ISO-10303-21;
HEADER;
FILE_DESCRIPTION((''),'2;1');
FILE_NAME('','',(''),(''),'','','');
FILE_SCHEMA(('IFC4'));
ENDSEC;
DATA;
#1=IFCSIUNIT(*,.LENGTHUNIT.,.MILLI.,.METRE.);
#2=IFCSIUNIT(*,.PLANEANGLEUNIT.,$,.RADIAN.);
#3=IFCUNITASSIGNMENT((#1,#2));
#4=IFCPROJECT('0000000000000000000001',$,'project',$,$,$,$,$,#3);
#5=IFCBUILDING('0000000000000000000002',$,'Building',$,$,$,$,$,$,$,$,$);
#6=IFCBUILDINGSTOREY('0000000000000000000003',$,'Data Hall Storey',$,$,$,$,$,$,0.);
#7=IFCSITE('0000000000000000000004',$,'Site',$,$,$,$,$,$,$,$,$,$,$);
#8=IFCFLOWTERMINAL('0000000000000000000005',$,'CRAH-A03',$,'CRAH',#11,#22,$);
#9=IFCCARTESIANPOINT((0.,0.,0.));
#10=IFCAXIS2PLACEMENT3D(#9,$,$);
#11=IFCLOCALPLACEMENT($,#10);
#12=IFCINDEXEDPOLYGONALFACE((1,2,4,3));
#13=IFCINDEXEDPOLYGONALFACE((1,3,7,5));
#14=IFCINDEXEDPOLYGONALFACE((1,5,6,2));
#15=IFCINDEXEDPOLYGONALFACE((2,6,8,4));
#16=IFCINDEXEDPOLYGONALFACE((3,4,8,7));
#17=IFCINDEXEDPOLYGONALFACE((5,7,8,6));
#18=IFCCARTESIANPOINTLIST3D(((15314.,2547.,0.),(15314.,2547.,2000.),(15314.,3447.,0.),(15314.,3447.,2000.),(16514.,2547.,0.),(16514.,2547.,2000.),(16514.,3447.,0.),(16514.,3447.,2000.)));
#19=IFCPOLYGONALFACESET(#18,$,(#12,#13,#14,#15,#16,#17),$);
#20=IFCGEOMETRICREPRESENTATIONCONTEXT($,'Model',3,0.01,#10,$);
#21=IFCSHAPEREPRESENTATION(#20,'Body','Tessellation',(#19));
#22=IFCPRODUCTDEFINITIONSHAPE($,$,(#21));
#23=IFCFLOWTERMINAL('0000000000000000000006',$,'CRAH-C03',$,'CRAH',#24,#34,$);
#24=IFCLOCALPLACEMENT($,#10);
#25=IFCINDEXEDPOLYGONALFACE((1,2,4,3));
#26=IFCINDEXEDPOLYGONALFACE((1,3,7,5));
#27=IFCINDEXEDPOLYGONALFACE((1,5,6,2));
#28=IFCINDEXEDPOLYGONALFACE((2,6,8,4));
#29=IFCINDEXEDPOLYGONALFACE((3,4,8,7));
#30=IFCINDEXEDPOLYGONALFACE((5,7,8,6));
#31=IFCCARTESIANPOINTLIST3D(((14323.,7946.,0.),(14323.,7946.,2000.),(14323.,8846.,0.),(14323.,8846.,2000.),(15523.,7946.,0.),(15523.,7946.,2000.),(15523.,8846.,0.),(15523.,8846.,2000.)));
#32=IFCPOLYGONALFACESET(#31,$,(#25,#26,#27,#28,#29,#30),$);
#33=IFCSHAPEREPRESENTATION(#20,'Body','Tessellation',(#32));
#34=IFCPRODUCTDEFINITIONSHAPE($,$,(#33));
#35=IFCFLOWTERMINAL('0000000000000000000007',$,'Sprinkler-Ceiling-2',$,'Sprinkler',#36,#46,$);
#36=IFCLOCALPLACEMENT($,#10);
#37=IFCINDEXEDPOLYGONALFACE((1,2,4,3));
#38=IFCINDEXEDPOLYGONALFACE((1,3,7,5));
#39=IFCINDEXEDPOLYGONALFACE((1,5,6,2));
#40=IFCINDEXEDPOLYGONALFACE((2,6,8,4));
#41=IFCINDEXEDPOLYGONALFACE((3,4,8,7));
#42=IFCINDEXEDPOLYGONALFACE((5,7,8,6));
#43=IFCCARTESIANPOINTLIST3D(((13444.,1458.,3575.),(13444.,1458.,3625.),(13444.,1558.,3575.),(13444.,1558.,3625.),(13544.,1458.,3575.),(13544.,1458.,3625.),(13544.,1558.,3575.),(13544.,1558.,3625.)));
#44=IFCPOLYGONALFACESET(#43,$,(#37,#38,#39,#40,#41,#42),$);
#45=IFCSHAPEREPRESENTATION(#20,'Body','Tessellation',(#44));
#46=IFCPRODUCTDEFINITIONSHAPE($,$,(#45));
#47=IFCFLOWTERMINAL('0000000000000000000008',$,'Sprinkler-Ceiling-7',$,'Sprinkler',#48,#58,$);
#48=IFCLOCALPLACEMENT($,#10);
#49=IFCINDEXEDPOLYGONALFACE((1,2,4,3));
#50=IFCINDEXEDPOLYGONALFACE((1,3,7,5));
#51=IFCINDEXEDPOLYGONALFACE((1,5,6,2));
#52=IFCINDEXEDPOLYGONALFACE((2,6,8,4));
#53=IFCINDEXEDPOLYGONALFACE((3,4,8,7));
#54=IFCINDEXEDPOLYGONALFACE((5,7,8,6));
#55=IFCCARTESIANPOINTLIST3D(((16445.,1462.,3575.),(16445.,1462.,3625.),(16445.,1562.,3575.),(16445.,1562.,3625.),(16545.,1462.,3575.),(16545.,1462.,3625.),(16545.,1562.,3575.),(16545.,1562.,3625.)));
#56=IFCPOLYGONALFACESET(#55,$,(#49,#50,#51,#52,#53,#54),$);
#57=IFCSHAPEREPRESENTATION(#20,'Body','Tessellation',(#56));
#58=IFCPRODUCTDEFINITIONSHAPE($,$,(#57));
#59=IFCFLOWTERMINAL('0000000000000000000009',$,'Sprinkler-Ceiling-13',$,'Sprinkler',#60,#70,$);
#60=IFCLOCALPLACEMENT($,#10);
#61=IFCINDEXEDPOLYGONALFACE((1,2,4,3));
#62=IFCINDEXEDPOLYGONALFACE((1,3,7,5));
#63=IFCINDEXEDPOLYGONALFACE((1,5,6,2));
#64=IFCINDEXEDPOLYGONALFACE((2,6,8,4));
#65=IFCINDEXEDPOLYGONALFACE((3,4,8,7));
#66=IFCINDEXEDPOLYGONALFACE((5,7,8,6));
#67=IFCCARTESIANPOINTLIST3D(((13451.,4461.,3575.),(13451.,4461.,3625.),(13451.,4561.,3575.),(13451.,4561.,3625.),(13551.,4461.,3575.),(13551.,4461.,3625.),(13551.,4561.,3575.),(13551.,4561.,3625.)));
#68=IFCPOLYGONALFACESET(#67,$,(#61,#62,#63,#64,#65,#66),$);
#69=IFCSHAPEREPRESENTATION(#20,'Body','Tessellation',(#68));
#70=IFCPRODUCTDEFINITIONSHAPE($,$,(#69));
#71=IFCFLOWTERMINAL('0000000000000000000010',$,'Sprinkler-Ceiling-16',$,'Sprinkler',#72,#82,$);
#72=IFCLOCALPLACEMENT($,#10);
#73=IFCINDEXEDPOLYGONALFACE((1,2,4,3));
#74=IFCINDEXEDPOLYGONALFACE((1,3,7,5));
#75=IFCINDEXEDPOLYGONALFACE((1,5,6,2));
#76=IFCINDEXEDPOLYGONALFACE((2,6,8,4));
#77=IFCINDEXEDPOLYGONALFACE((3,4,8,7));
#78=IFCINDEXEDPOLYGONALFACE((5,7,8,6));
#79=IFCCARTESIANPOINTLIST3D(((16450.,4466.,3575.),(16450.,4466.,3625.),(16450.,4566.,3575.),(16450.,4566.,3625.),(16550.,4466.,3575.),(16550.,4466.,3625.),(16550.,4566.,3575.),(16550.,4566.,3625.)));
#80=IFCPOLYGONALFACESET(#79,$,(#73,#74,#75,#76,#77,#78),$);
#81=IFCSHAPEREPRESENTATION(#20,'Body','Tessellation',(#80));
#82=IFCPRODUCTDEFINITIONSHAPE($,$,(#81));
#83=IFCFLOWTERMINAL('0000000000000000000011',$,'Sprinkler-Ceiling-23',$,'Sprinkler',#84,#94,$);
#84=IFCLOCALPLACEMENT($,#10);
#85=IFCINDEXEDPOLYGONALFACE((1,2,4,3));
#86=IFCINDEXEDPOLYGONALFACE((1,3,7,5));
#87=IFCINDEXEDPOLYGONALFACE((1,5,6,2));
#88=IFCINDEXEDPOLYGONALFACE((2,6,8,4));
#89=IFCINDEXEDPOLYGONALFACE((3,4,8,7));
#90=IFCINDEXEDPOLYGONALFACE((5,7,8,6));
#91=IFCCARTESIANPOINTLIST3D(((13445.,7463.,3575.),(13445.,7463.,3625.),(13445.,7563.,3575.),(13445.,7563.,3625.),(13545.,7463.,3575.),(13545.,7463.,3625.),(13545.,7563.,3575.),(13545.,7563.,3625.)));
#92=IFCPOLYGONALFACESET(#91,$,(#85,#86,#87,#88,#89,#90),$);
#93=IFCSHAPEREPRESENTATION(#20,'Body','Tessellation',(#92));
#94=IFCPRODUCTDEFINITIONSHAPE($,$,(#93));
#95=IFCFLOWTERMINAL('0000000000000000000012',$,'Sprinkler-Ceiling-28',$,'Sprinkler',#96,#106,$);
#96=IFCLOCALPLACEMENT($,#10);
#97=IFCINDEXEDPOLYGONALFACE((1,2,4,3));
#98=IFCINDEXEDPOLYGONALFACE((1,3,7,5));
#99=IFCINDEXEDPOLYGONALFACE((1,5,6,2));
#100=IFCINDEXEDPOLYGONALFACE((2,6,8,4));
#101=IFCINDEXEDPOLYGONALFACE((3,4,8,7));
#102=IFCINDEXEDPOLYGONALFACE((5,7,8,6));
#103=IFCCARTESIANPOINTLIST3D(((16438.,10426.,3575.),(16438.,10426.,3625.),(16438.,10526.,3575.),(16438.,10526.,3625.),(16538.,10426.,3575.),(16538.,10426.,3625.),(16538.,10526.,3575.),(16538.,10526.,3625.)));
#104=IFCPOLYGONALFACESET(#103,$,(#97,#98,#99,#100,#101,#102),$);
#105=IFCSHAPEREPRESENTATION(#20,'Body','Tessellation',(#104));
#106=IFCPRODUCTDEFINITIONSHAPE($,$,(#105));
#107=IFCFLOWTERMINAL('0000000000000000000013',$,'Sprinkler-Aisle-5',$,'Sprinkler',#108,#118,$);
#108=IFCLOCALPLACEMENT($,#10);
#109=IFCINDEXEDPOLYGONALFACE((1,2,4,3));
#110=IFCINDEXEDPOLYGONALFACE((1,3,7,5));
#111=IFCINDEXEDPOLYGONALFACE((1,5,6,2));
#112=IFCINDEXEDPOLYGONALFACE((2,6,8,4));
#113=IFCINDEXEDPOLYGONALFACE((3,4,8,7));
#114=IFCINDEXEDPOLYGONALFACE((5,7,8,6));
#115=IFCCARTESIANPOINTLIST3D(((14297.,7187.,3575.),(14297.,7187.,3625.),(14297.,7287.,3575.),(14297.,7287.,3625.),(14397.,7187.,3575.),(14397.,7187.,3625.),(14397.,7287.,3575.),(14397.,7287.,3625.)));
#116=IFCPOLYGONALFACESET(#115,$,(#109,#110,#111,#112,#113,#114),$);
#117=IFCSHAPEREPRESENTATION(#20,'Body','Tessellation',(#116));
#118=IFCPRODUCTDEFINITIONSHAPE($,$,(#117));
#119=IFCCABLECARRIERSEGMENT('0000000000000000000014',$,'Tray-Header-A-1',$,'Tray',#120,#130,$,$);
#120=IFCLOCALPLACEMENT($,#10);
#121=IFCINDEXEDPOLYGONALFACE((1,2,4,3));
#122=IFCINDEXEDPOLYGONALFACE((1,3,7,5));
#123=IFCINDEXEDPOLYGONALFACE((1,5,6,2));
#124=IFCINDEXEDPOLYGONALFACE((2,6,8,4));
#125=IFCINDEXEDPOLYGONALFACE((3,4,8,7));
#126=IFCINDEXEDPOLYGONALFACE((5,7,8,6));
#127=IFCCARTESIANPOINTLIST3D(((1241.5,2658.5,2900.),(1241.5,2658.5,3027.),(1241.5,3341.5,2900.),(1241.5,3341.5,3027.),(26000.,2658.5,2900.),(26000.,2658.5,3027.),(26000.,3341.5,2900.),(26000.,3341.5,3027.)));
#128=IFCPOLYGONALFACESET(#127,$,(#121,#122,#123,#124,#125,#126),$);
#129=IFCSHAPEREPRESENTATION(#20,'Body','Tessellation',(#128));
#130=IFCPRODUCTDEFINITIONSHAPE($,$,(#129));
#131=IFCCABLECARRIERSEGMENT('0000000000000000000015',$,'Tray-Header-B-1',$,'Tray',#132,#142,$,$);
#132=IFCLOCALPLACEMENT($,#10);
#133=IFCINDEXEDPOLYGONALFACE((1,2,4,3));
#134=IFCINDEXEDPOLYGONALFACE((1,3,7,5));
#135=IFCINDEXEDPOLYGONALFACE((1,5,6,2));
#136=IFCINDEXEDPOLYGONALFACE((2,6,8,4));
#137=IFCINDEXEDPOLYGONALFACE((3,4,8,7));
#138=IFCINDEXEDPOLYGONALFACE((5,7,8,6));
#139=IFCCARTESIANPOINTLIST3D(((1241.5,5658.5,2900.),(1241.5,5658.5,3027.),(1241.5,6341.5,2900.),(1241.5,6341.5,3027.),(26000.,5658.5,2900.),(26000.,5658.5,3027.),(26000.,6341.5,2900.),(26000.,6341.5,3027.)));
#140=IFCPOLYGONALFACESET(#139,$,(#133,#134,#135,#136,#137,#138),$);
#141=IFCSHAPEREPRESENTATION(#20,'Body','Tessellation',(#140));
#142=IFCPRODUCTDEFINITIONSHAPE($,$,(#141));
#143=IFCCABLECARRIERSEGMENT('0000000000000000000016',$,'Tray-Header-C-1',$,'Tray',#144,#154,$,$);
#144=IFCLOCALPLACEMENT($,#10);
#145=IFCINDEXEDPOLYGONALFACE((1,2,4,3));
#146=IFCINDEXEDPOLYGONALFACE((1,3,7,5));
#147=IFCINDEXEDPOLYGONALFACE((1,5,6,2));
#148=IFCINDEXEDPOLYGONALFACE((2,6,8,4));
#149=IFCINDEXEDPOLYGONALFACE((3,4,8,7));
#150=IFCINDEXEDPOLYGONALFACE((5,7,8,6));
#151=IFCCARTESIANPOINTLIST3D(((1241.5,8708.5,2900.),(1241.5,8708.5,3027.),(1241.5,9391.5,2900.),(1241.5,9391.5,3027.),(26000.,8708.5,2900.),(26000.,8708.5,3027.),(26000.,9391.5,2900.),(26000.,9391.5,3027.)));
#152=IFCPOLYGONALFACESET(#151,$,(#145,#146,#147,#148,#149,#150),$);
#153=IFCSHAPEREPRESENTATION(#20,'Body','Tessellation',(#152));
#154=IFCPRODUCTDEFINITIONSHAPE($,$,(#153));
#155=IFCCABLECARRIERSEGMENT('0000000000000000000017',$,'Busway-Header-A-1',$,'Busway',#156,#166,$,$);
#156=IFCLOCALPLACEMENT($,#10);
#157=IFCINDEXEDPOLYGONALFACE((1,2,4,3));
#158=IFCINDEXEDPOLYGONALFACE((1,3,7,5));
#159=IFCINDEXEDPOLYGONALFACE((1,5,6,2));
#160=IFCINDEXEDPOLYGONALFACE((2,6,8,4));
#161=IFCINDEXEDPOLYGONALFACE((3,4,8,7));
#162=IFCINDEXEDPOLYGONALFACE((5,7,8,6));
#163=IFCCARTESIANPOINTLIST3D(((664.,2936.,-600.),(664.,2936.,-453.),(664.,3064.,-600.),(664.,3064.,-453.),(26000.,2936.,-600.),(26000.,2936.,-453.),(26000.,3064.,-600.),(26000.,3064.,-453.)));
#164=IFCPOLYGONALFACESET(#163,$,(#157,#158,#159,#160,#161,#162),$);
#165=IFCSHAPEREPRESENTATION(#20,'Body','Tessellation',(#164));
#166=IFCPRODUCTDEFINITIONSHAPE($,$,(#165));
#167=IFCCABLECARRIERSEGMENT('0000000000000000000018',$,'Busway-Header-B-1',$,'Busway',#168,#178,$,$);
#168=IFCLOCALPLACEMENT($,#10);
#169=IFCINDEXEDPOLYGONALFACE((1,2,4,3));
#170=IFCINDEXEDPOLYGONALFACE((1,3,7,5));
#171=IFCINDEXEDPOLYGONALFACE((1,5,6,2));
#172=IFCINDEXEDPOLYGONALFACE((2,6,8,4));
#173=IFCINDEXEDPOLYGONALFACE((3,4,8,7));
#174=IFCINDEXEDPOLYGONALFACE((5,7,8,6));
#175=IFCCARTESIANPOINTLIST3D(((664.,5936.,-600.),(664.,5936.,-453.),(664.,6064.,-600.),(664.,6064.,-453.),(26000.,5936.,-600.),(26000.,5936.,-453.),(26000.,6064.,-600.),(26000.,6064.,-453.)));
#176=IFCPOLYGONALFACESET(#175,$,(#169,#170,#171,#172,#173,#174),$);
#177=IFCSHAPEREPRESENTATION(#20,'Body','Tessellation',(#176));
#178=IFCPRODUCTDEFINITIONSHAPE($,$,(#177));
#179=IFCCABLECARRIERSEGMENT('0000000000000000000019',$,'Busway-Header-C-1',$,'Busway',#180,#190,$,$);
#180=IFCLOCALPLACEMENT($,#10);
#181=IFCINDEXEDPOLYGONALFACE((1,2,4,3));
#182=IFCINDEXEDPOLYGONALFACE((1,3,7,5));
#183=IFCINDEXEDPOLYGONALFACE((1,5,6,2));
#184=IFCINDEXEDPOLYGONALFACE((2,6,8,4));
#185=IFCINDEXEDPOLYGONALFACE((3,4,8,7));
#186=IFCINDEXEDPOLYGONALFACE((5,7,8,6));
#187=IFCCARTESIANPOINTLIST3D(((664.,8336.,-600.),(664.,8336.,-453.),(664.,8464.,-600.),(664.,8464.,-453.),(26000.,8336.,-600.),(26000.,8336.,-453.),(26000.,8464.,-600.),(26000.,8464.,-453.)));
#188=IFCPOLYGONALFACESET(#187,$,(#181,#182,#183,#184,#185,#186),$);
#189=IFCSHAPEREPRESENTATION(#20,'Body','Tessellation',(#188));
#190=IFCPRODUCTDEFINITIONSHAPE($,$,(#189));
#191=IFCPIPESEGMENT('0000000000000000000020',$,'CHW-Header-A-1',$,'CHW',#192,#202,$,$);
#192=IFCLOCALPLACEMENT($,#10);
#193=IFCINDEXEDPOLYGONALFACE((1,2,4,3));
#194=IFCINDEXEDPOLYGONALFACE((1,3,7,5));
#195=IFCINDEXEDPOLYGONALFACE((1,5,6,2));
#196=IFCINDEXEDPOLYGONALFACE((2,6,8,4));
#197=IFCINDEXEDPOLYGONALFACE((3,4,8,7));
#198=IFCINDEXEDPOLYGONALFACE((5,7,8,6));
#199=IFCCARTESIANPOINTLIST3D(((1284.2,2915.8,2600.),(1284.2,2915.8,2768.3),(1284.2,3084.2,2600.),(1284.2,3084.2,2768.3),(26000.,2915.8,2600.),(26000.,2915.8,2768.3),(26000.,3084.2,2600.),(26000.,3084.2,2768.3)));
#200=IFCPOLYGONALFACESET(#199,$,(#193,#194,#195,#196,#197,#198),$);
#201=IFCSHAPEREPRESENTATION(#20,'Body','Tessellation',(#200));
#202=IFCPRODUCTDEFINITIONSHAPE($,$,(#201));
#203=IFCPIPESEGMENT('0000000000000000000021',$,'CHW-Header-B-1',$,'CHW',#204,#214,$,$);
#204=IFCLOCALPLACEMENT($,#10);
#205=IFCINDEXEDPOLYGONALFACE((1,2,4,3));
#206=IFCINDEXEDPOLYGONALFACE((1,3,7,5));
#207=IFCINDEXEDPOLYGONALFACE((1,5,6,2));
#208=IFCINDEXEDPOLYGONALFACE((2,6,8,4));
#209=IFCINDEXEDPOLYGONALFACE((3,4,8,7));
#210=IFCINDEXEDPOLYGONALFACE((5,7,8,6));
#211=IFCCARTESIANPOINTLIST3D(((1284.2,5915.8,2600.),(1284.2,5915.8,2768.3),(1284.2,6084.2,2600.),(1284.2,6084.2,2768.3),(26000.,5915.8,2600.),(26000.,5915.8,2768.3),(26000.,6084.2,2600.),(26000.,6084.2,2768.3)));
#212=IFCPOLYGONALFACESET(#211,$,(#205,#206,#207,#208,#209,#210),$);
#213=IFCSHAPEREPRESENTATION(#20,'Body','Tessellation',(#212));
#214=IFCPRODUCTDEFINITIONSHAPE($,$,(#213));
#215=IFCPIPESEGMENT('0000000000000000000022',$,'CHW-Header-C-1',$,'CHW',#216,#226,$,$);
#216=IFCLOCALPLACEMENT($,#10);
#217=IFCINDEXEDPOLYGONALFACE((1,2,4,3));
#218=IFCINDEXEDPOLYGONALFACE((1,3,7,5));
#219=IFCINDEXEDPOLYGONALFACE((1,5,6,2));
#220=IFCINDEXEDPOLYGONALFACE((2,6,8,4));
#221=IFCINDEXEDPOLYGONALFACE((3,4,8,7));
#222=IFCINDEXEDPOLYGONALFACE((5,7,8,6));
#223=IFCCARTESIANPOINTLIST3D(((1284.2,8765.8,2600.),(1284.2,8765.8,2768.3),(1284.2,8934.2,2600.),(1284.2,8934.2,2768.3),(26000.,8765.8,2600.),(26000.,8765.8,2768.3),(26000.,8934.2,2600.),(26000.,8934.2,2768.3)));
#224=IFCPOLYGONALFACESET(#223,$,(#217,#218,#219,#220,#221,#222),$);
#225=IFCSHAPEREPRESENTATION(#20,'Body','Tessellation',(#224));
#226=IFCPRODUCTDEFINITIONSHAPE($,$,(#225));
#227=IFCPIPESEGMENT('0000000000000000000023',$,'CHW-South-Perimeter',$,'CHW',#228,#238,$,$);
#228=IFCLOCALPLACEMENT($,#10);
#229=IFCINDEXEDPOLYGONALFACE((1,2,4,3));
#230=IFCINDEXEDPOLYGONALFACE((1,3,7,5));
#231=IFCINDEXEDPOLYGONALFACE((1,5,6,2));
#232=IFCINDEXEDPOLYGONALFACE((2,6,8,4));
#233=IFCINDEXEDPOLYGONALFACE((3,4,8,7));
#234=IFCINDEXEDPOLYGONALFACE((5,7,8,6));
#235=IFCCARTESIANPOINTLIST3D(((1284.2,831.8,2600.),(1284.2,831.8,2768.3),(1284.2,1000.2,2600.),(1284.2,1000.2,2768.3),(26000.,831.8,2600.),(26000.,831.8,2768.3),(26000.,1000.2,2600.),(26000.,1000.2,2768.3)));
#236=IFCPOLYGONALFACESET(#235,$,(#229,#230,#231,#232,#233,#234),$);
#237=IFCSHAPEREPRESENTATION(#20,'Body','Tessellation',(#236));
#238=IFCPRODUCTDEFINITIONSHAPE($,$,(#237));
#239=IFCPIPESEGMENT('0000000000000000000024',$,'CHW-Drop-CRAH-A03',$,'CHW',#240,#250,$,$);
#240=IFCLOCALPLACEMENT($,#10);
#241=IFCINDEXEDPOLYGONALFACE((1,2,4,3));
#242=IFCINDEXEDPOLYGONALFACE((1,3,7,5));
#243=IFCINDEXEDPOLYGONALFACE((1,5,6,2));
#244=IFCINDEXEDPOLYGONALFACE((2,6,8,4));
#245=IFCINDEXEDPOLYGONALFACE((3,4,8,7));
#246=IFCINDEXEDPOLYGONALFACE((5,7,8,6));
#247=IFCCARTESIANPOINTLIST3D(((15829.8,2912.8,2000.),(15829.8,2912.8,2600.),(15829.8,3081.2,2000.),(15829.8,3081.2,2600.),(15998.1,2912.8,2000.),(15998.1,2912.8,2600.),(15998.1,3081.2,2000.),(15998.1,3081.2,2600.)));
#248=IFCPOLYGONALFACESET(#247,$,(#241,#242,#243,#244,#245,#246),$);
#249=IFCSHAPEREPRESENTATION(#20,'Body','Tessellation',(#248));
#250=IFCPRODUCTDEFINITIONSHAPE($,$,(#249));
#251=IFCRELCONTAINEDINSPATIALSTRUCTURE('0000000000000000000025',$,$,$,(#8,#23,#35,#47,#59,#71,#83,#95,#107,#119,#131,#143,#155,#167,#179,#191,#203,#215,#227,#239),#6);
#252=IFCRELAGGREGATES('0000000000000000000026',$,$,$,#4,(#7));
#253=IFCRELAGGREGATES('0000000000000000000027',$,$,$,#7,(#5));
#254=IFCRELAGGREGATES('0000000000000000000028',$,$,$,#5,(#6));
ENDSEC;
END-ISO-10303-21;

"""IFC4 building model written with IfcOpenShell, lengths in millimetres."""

from ifc_helpers import new_model, si_unit, frame, origin, place, context, project, spatial, rectangle, extrude, element, save


model = new_model("IFC4")

# Units and contexts
model_context = context("Model", 3, precision=0.01, world=origin())
ifc_project = project(units=[si_unit("LENGTHUNIT", "METRE", prefix="MILLI"), si_unit("PLANEANGLEUNIT", "RADIAN")])

# Site, building, storey
site = spatial("IfcSite", under=ifc_project, Name="Site")
building = spatial("IfcBuilding", under=site, Name="Building")
storey = spatial("IfcBuildingStorey", under=building, Name="Data Hall Storey", Elevation=0.0)

# Flow terminals
for number, where, name in (
    (1, (15914.0, 2997.0, 0.0), "CRAH-A03"),
    (2, (14923.0, 8396.0, 0.0), "CRAH-C03"),
):
    element("IfcFlowTerminal", number, at=place(None, frame(where)), inside=storey, Name=name, ObjectType="CRAH", context=model_context, shape_type="SweptSolid", body=[
        extrude(rectangle(XDim=1200.0, YDim=900.0), origin(), (0.0, 0.0, 1.0), 2000.0),
    ])
for number, where, name in (
    (3, (13494.0, 1508.0, 3575.0), "Sprinkler-Ceiling-2"),
    (4, (16495.0, 1512.0, 3575.0), "Sprinkler-Ceiling-7"),
    (5, (13501.0, 4511.0, 3575.0), "Sprinkler-Ceiling-13"),
    (6, (16500.0, 4516.0, 3575.0), "Sprinkler-Ceiling-16"),
    (7, (13495.0, 7513.0, 3575.0), "Sprinkler-Ceiling-23"),
    (8, (16488.0, 10476.0, 3575.0), "Sprinkler-Ceiling-28"),
    (9, (14347.0, 7237.0, 3575.0), "Sprinkler-Aisle-5"),
):
    element("IfcFlowTerminal", number, at=place(None, frame(where)), inside=storey, Name=name, ObjectType="Sprinkler", context=model_context, shape_type="SweptSolid", body=[
        extrude(rectangle(XDim=100.0, YDim=100.0), origin(), (0.0, 0.0, 1.0), 50.0),
    ])

# Cable carrier segments
for number, where, name in (
    (10, (13620.8, 3000.0, 2900.0), "Tray-Header-A-1"),
    (11, (13620.8, 6000.0, 2900.0), "Tray-Header-B-1"),
    (12, (13620.8, 9050.0, 2900.0), "Tray-Header-C-1"),
):
    element("IfcCableCarrierSegment", number, at=place(None, frame(where)), inside=storey, Name=name, ObjectType="Tray", context=model_context, shape_type="SweptSolid", body=[
        extrude(rectangle(XDim=24758.5, YDim=683.0), origin(), (0.0, 0.0, 1.0), 127.0),
    ])
for number, where, name in (
    (13, (13332.0, 3000.0, -600.0), "Busway-Header-A-1"),
    (14, (13332.0, 6000.0, -600.0), "Busway-Header-B-1"),
    (15, (13332.0, 8400.0, -600.0), "Busway-Header-C-1"),
):
    element("IfcCableCarrierSegment", number, at=place(None, frame(where)), inside=storey, Name=name, ObjectType="Busway", context=model_context, shape_type="SweptSolid", body=[
        extrude(rectangle(XDim=25336.0, YDim=128.0), origin(), (0.0, 0.0, 1.0), 147.0),
    ])

# Pipe segments
for number, where, name in (
    (16, (13642.1, 3000.0, 2600.0), "CHW-Header-A-1"),
    (17, (13642.1, 6000.0, 2600.0), "CHW-Header-B-1"),
    (18, (13642.1, 8850.0, 2600.0), "CHW-Header-C-1"),
    (19, (13642.1, 916.0, 2600.0), "CHW-South-Perimeter"),
):
    element("IfcPipeSegment", number, at=place(None, frame(where)), inside=storey, Name=name, ObjectType="CHW", context=model_context, shape_type="SweptSolid", body=[
        extrude(rectangle(XDim=24715.8, YDim=168.3), origin(), (0.0, 0.0, 1.0), 168.3),
    ])
pipe_segment_1_placement = place(None, frame((15914.0, 2997.0, 2000.0)))
element("IfcPipeSegment", 20, at=pipe_segment_1_placement, inside=storey, Name="CHW-Drop-CRAH-A03", ObjectType="CHW", context=model_context, shape_type="SweptSolid", body=[
    extrude(rectangle(XDim=168.3, YDim=168.3), origin(), (0.0, 0.0, 1.0), 600.0),
])

save(model, "model.ifc")
